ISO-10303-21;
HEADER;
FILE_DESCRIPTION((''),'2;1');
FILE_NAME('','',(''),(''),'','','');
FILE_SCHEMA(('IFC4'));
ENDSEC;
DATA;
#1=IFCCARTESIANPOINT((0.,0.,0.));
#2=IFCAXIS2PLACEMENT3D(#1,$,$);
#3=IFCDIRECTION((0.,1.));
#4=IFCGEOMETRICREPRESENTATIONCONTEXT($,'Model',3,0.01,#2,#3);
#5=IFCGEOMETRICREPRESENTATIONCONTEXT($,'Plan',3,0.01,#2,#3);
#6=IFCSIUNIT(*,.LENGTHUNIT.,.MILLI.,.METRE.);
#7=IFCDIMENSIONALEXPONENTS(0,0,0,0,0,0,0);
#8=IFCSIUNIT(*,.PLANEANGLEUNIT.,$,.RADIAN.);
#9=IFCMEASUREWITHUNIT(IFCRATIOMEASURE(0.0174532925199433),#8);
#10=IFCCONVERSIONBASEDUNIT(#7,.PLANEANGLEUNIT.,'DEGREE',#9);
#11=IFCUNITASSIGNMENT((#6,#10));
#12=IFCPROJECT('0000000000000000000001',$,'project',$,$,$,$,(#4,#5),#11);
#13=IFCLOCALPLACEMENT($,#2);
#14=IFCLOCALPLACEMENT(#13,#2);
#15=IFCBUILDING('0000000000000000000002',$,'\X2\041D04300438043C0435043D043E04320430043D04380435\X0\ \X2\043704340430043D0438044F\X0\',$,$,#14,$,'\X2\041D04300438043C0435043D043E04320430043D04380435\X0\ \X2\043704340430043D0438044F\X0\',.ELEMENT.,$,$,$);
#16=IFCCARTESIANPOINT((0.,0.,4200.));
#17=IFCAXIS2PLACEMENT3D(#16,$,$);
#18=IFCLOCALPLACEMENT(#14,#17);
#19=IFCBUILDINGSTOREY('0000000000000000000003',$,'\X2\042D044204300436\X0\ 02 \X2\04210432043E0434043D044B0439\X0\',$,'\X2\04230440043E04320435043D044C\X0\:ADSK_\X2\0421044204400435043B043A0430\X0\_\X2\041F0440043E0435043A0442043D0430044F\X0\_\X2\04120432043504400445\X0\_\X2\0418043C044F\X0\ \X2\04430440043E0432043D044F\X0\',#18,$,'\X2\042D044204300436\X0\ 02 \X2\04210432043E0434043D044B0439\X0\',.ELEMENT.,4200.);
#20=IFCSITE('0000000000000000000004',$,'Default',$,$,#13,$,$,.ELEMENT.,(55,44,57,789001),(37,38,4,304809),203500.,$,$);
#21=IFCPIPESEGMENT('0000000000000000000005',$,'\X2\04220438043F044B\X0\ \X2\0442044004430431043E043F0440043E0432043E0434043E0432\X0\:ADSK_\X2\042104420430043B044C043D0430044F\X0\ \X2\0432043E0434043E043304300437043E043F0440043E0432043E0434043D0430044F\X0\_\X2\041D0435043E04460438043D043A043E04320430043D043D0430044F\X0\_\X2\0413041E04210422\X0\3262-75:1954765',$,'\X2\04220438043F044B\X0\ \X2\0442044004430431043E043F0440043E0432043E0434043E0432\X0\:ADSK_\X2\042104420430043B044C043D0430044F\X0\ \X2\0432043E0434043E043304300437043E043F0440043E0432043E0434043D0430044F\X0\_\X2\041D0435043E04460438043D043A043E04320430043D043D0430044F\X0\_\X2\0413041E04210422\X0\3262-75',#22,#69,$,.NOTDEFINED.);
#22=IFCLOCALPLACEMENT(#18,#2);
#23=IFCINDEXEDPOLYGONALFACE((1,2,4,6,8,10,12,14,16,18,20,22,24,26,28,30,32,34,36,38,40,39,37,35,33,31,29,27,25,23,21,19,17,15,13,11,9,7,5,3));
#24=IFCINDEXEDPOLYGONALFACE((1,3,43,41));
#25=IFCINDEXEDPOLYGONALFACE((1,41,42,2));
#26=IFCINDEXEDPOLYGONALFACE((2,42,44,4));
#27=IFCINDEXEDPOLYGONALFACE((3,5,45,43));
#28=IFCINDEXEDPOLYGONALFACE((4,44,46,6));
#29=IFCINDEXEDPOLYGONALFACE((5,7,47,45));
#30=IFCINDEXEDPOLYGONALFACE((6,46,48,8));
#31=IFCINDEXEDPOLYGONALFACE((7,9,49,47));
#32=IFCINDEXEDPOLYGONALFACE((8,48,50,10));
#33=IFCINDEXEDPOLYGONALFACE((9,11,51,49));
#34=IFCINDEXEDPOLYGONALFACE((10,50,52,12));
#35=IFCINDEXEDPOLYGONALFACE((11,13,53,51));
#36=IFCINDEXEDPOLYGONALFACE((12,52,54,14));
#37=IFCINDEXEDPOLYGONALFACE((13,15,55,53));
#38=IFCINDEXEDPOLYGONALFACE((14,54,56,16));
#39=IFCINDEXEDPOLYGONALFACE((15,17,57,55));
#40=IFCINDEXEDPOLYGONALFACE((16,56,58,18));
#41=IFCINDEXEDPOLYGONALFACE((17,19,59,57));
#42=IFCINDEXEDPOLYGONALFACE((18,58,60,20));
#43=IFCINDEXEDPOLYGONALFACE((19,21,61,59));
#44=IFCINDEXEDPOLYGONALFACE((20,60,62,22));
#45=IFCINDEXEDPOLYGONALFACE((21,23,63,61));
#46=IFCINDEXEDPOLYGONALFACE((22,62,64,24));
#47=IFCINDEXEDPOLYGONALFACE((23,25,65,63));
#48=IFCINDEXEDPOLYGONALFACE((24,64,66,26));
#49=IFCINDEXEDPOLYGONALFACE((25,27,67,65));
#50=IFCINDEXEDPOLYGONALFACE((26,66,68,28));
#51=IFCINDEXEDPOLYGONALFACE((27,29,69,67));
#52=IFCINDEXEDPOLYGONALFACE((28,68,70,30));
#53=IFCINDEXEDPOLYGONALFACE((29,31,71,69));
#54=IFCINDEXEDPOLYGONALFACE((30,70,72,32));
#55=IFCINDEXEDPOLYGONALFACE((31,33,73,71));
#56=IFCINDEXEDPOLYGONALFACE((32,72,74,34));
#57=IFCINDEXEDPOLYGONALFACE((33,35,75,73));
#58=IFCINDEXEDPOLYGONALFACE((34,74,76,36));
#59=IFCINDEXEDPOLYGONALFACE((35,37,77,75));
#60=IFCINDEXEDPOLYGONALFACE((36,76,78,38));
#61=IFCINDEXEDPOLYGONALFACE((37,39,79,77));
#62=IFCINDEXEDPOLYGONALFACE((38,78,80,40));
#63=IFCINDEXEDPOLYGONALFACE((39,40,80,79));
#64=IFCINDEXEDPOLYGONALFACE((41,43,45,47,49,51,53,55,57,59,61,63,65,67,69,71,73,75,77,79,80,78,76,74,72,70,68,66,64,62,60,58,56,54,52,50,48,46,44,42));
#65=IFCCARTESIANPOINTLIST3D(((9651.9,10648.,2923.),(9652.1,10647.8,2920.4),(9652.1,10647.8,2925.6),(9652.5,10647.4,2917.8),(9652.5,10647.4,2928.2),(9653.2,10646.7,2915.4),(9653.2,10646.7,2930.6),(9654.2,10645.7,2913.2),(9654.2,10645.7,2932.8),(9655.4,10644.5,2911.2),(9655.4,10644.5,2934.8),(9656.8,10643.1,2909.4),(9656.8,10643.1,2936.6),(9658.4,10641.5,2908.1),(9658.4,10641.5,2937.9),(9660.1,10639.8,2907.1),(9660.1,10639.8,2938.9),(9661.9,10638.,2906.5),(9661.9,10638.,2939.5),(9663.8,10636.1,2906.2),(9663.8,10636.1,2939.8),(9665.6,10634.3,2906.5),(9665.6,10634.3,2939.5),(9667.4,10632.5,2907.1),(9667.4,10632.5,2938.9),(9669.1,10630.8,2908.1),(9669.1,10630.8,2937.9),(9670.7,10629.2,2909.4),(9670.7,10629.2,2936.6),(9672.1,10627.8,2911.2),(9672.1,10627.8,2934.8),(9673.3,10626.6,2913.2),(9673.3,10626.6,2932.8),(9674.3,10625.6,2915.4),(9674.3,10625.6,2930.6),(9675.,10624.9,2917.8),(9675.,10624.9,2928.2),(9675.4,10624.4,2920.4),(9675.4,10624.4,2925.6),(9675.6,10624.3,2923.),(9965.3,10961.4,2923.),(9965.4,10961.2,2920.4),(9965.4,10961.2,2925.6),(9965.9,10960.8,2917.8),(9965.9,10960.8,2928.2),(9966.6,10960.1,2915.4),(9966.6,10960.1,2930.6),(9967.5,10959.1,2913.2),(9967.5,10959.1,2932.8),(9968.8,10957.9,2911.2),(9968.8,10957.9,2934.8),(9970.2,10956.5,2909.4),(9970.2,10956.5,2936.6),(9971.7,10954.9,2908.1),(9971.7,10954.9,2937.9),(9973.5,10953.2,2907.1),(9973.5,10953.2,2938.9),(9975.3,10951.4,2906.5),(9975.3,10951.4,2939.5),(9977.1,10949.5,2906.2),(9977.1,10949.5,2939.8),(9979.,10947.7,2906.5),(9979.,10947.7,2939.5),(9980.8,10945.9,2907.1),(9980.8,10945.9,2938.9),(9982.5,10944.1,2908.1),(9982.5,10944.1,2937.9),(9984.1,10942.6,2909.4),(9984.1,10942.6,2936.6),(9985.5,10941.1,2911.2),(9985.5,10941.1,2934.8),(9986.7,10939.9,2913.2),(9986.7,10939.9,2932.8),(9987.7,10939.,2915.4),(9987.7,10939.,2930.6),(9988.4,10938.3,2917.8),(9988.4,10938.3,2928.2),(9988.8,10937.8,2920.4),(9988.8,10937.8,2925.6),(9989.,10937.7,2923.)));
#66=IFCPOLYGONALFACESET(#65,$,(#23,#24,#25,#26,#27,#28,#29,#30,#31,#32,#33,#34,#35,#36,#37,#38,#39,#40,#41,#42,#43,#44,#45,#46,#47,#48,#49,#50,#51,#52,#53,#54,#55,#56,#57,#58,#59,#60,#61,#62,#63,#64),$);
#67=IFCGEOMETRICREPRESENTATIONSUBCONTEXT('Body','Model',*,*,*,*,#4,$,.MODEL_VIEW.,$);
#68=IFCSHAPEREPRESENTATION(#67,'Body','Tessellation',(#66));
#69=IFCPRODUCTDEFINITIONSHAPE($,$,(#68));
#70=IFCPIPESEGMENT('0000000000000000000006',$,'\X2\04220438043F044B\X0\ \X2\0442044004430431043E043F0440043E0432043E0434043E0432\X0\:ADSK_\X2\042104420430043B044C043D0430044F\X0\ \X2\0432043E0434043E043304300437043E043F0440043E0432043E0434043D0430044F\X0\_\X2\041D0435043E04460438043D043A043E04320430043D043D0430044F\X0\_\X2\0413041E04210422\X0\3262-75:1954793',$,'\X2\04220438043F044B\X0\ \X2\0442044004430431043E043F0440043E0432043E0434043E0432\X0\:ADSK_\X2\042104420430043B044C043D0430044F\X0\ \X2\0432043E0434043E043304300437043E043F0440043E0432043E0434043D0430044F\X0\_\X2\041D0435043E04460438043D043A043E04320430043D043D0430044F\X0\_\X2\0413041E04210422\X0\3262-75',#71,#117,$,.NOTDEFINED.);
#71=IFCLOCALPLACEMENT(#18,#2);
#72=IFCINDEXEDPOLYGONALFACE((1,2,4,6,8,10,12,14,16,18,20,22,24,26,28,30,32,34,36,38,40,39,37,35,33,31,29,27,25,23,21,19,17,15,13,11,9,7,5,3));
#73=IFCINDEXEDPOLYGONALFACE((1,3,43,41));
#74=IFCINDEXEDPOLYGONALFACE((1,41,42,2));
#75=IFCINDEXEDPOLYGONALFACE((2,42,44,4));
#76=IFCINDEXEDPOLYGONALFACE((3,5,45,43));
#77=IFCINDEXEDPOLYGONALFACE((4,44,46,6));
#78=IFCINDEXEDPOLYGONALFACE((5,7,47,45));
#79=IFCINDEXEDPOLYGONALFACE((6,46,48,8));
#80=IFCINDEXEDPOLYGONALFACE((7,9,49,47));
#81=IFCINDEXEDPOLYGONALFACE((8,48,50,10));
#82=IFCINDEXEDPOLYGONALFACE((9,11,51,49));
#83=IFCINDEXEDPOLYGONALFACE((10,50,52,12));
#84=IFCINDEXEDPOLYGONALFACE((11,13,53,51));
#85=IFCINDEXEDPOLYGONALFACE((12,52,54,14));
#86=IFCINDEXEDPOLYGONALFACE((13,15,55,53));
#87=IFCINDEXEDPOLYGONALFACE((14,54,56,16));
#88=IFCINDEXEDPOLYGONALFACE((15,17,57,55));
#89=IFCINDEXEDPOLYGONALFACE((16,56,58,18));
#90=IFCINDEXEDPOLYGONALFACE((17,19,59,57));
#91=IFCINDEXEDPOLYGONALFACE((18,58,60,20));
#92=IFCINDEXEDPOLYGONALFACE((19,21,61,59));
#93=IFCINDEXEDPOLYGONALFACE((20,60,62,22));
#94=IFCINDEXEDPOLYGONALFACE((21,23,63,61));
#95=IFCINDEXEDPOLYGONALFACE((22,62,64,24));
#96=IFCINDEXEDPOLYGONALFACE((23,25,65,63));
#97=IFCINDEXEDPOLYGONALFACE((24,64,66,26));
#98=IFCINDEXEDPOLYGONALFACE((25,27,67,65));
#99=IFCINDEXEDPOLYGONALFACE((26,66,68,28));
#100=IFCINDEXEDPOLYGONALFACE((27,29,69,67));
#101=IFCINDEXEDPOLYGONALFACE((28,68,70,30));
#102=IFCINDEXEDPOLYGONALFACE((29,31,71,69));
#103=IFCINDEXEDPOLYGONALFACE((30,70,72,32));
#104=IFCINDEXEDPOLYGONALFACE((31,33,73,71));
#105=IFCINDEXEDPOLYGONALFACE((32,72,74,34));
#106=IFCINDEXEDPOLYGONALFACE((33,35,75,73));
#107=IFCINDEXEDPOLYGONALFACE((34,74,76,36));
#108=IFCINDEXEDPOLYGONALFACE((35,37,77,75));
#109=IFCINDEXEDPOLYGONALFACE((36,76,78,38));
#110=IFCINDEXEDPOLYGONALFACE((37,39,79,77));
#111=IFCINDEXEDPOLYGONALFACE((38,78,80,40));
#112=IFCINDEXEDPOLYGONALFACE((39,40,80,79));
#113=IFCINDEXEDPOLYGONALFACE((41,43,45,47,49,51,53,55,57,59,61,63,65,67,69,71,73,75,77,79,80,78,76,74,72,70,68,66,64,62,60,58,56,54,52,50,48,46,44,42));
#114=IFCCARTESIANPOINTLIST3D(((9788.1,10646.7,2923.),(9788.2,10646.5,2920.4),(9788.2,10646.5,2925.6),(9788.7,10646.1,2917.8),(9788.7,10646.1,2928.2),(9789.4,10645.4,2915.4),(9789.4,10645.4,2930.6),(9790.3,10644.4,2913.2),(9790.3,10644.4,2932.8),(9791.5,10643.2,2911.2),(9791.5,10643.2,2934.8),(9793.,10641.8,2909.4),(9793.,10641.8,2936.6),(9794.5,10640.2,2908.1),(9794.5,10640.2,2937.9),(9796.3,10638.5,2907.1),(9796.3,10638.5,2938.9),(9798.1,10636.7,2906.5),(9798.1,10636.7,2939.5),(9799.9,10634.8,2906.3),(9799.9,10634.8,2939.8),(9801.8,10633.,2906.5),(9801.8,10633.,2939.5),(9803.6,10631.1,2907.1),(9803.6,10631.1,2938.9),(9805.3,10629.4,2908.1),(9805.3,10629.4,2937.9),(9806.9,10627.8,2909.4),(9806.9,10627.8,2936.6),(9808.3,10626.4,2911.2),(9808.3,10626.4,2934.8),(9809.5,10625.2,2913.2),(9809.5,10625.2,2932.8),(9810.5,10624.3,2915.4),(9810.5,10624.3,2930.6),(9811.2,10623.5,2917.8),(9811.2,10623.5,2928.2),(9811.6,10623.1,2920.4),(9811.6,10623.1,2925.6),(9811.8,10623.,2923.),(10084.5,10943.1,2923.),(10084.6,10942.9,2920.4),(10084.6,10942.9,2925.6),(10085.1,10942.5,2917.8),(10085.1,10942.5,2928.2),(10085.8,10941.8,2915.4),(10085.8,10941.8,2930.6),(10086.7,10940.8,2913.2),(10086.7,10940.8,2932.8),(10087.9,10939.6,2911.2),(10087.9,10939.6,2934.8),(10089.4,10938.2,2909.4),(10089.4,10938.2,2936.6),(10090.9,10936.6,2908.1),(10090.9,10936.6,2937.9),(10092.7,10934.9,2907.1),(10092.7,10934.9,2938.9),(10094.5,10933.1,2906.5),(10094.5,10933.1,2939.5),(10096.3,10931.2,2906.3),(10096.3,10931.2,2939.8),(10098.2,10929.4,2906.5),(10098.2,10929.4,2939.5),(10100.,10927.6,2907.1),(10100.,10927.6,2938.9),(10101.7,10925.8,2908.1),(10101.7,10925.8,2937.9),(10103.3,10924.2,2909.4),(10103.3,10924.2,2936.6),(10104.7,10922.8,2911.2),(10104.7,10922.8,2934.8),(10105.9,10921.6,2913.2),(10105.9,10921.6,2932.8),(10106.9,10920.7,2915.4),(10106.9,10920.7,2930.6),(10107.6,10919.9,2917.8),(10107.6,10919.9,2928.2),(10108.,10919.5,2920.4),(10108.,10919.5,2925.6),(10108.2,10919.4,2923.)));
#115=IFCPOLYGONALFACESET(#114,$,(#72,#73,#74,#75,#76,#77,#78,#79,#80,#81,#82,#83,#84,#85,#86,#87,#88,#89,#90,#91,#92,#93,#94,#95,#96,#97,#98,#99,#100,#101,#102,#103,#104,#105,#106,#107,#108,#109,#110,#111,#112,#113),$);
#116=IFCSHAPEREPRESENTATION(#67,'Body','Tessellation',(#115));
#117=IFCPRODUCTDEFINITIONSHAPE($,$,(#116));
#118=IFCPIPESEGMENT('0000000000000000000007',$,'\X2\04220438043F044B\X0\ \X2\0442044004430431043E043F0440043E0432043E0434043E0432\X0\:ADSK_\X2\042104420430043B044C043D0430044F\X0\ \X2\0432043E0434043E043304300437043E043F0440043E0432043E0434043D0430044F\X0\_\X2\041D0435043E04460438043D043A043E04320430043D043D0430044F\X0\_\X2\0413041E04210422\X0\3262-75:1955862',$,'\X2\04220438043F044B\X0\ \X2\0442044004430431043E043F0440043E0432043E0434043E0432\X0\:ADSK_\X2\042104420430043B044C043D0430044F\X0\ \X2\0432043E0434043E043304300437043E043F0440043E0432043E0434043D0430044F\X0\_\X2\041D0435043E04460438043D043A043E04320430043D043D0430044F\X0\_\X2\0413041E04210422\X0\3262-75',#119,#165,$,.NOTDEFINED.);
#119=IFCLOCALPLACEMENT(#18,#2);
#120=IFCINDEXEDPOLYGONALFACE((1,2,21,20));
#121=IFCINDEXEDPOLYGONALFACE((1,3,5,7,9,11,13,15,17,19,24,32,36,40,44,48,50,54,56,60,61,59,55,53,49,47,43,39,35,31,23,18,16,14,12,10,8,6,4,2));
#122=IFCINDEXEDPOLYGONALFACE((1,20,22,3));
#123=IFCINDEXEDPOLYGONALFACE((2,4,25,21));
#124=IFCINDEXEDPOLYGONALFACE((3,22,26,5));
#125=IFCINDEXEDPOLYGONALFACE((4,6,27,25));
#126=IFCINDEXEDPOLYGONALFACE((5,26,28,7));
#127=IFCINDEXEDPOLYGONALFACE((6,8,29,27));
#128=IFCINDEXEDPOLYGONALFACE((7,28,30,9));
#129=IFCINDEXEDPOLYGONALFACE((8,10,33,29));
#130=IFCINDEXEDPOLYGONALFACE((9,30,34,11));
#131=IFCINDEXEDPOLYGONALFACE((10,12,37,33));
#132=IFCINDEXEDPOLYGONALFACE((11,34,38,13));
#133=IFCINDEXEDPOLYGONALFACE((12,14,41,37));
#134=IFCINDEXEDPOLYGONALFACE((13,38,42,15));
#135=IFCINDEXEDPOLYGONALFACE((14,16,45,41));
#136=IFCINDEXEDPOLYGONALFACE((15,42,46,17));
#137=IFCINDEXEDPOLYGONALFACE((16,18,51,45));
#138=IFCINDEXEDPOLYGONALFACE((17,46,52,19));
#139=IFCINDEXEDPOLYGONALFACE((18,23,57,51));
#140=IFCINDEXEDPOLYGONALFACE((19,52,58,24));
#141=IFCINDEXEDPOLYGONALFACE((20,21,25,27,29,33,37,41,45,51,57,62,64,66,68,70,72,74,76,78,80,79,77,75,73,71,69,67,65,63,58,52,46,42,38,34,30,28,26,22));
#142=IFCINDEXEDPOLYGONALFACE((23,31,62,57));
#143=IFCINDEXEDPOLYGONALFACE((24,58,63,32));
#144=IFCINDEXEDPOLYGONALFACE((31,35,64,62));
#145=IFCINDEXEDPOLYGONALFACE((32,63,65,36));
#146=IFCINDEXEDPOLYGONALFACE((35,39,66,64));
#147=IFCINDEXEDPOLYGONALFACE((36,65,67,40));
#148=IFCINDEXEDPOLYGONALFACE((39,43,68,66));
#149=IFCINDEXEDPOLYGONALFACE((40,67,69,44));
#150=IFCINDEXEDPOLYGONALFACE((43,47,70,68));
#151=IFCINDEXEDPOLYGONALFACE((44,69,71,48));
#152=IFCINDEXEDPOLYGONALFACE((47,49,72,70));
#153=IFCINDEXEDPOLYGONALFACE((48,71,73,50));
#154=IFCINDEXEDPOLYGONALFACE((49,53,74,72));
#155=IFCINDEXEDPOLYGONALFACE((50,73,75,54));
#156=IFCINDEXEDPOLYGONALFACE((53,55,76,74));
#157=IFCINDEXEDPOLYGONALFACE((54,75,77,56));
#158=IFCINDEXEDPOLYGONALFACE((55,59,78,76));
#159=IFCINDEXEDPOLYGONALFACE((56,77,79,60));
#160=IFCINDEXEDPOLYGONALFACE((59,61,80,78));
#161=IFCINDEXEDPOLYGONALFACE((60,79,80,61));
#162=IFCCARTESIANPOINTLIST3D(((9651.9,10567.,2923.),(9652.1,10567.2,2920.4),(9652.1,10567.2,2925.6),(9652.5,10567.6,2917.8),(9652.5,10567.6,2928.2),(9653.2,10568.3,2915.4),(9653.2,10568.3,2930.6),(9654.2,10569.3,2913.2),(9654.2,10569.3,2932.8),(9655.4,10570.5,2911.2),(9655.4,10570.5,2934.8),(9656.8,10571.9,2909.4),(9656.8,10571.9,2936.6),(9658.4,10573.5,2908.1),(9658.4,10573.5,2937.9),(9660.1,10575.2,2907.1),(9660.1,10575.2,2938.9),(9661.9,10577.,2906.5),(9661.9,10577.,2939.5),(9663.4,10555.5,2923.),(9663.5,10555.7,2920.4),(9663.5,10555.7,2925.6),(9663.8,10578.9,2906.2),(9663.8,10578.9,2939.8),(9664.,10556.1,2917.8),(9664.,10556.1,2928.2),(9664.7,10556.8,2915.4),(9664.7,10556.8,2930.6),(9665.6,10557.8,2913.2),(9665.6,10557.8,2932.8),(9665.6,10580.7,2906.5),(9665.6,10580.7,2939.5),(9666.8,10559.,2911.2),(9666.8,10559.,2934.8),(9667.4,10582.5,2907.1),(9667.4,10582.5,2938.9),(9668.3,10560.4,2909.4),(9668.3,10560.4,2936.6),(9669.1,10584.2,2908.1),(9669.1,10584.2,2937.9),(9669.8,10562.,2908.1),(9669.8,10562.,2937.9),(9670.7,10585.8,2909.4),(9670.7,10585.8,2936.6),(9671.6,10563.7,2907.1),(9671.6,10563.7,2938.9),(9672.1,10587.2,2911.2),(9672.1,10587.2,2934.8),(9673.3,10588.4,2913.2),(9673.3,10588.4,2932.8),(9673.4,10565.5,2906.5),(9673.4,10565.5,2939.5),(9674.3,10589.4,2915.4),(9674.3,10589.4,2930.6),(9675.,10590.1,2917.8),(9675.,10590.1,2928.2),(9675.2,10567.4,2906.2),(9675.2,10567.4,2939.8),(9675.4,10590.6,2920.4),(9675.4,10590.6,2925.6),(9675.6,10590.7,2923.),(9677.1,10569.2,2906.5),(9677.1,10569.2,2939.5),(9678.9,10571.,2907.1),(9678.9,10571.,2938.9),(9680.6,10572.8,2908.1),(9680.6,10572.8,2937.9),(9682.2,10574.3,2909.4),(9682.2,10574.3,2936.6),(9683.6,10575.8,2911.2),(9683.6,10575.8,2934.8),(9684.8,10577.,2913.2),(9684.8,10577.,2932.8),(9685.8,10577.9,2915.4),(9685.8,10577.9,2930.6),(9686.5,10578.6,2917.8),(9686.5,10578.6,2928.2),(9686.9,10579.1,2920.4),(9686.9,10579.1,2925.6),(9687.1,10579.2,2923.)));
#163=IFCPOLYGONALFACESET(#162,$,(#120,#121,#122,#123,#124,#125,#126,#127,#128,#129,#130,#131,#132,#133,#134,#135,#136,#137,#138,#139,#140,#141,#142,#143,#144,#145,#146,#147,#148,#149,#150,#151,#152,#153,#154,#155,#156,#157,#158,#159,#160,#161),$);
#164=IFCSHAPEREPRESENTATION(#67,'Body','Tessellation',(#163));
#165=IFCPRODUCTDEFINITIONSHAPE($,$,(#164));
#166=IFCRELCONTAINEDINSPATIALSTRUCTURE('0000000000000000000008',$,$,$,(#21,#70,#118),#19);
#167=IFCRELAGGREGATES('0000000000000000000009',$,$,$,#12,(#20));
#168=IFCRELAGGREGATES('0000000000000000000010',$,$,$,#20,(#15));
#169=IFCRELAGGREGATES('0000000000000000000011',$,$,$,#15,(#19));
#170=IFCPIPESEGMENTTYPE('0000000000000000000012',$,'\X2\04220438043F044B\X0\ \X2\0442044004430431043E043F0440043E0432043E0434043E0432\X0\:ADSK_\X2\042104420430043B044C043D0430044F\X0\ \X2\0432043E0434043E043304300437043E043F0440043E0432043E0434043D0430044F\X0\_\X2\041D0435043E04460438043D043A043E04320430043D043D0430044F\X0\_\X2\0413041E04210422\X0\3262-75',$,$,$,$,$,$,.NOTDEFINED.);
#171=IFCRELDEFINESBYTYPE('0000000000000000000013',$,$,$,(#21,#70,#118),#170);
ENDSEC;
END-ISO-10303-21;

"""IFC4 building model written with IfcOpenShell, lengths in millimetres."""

from ifc_helpers import new_model, entity, si_unit, converted_unit, direction, frame, origin, place, context, subcontext, project, spatial, indexed_curve, outline, extrude, type_object, element, save


model = new_model("IFC4")

# Units and contexts
model_context = context("Model", 3, precision=0.01, world=origin(), true_north=direction((0.0, 1.0)))
plan_context = context("Plan", 3, precision=0.01, world=origin(), true_north=direction((0.0, 1.0)))
body_context = subcontext(model_context, "Body", "Model", "MODEL_VIEW")
ifc_project = project(units=[si_unit("LENGTHUNIT", "METRE", prefix="MILLI"), converted_unit("PLANEANGLEUNIT", "DEGREE", entity("IfcRatioMeasure", 0.0174532925199433), si_unit("PLANEANGLEUNIT", "RADIAN"), dimensions=[0, 0, 0, 0, 0, 0, 0])], contexts=[model_context, plan_context])

# Site, building, storey
site_placement = place(None, origin())
site = spatial("IfcSite", under=ifc_project, at=site_placement, Name="Default", CompositionType="ELEMENT", RefLatitude=(55, 44, 57, 789001), RefLongitude=(37, 38, 4, 304809), RefElevation=203500.0)
building_placement = place(site_placement, origin())
building = spatial("IfcBuilding", under=site, at=building_placement, Name="Наименование здания", LongName="Наименование здания", CompositionType="ELEMENT")
storey_placement = place(building_placement, frame((0.0, 0.0, 4200.0)))
storey = spatial("IfcBuildingStorey", under=building, at=storey_placement, Name="Этаж 02 Сводный", ObjectType="Уровень:ADSK_Стрелка_Проектная_Вверх_Имя уровня", LongName="Этаж 02 Сводный", CompositionType="ELEMENT", Elevation=4200.0)

# Pipe segments
placement = place(storey_placement, origin())
pipe_segment_type_1 = type_object("IfcPipeSegmentType", Name="Типы трубопроводов:ADSK_Стальная водогазопроводная_Неоцинкованная_ГОСТ3262-75", PredefinedType="NOTDEFINED")
element("IfcPipeSegment", 1, at=placement, inside=storey, type_object=pipe_segment_type_1, Name="Типы трубопроводов:ADSK_Стальная водогазопроводная_Неоцинкованная_ГОСТ3262-75:1954765", ObjectType="Типы трубопроводов:ADSK_Стальная водогазопроводная_Неоцинкованная_ГОСТ3262-75", PredefinedType="NOTDEFINED", context=body_context, shape_type="SweptSolid", body=[
    extrude(outline(indexed_curve([(16.8, 0.0), (16.5, 2.6), (15.9, 5.2), (14.9, 7.6), (13.6, 9.8), (11.8, 11.8), (9.8, 13.6), (7.6, 14.9), (5.2, 15.9), (2.6, 16.5), (0.0, 16.8), (-2.6, 16.5), (-5.2, 15.9), (-7.6, 14.9), (-9.8, 13.6), (-11.8, 11.8), (-13.6, 9.8), (-14.9, 7.6), (-15.9, 5.2), (-16.5, 2.6), (-16.8, 0.0), (-16.5, -2.6), (-15.9, -5.2), (-14.9, -7.6), (-13.6, -9.8), (-11.8, -11.8), (-9.8, -13.6), (-7.6, -14.9), (-5.2, -15.9), (-2.6, -16.5), (0.0, -16.8), (2.6, -16.5), (5.2, -15.9), (7.6, -14.9), (9.8, -13.6), (11.8, -11.8), (13.6, -9.8), (14.9, -7.6), (15.9, -5.2), (16.5, -2.6), (16.8, 0.0)], self_intersect=False)), frame((9663.8, 10636.1, 2923.0), z_axis=(0.707107, 0.707107, 0.0), x_axis=(-0.707107, 0.707107, 0.0)), (0.0, 0.0, 1.0), 443.2),
])
element("IfcPipeSegment", 2, at=placement, inside=storey, type_object=pipe_segment_type_1, Name="Типы трубопроводов:ADSK_Стальная водогазопроводная_Неоцинкованная_ГОСТ3262-75:1954793", ObjectType="Типы трубопроводов:ADSK_Стальная водогазопроводная_Неоцинкованная_ГОСТ3262-75", PredefinedType="NOTDEFINED", context=body_context, shape_type="SweptSolid", body=[
    extrude(outline(indexed_curve([(16.8, 0.0), (16.5, 2.6), (15.9, 5.2), (14.9, 7.6), (13.6, 9.8), (11.8, 11.8), (9.8, 13.6), (7.6, 14.9), (5.2, 15.9), (2.6, 16.5), (0.0, 16.8), (-2.6, 16.5), (-5.2, 15.9), (-7.6, 14.9), (-9.8, 13.6), (-11.8, 11.8), (-13.6, 9.8), (-14.9, 7.6), (-15.9, 5.2), (-16.5, 2.6), (-16.8, 0.0), (-16.5, -2.6), (-15.9, -5.2), (-14.9, -7.6), (-13.6, -9.8), (-11.8, -11.8), (-9.8, -13.6), (-7.6, -14.9), (-5.2, -15.9), (-2.6, -16.5), (0.0, -16.7), (2.6, -16.5), (5.2, -15.9), (7.6, -14.9), (9.8, -13.6), (11.8, -11.8), (13.6, -9.8), (14.9, -7.6), (15.9, -5.2), (16.5, -2.6), (16.8, 0.0)], self_intersect=False)), frame((9799.9, 10634.8, 2923.0), z_axis=(0.707107, 0.707107, 0.0), x_axis=(-0.707107, 0.707107, 0.0)), (0.0, 0.0, 1.0), 419.2),
])
element("IfcPipeSegment", 3, at=placement, inside=storey, type_object=pipe_segment_type_1, Name="Типы трубопроводов:ADSK_Стальная водогазопроводная_Неоцинкованная_ГОСТ3262-75:1955862", ObjectType="Типы трубопроводов:ADSK_Стальная водогазопроводная_Неоцинкованная_ГОСТ3262-75", PredefinedType="NOTDEFINED", context=body_context, shape_type="SweptSolid", body=[
    extrude(outline(indexed_curve([(16.7, 0.0), (16.5, 2.6), (15.9, 5.2), (14.9, 7.6), (13.6, 9.8), (11.8, 11.8), (9.8, 13.6), (7.6, 14.9), (5.2, 15.9), (2.6, 16.5), (0.0, 16.8), (-2.6, 16.5), (-5.2, 15.9), (-7.6, 14.9), (-9.8, 13.6), (-11.8, 11.8), (-13.6, 9.8), (-14.9, 7.6), (-15.9, 5.2), (-16.5, 2.6), (-16.7, 0.0), (-16.5, -2.6), (-15.9, -5.2), (-14.9, -7.6), (-13.6, -9.8), (-11.8, -11.8), (-9.8, -13.6), (-7.6, -14.9), (-5.2, -15.9), (-2.6, -16.5), (0.0, -16.8), (2.6, -16.5), (5.2, -15.9), (7.6, -14.9), (9.8, -13.6), (11.8, -11.8), (13.6, -9.8), (14.9, -7.6), (15.9, -5.2), (16.5, -2.6), (16.7, 0.0)], self_intersect=False)), frame((9663.8, 10578.9, 2923.0), z_axis=(0.707107, -0.707107, 0.0), x_axis=(-0.707107, -0.707107, 0.0)), (0.0, 0.0, 1.0), 16.2),
])

save(model, "model.ifc")
